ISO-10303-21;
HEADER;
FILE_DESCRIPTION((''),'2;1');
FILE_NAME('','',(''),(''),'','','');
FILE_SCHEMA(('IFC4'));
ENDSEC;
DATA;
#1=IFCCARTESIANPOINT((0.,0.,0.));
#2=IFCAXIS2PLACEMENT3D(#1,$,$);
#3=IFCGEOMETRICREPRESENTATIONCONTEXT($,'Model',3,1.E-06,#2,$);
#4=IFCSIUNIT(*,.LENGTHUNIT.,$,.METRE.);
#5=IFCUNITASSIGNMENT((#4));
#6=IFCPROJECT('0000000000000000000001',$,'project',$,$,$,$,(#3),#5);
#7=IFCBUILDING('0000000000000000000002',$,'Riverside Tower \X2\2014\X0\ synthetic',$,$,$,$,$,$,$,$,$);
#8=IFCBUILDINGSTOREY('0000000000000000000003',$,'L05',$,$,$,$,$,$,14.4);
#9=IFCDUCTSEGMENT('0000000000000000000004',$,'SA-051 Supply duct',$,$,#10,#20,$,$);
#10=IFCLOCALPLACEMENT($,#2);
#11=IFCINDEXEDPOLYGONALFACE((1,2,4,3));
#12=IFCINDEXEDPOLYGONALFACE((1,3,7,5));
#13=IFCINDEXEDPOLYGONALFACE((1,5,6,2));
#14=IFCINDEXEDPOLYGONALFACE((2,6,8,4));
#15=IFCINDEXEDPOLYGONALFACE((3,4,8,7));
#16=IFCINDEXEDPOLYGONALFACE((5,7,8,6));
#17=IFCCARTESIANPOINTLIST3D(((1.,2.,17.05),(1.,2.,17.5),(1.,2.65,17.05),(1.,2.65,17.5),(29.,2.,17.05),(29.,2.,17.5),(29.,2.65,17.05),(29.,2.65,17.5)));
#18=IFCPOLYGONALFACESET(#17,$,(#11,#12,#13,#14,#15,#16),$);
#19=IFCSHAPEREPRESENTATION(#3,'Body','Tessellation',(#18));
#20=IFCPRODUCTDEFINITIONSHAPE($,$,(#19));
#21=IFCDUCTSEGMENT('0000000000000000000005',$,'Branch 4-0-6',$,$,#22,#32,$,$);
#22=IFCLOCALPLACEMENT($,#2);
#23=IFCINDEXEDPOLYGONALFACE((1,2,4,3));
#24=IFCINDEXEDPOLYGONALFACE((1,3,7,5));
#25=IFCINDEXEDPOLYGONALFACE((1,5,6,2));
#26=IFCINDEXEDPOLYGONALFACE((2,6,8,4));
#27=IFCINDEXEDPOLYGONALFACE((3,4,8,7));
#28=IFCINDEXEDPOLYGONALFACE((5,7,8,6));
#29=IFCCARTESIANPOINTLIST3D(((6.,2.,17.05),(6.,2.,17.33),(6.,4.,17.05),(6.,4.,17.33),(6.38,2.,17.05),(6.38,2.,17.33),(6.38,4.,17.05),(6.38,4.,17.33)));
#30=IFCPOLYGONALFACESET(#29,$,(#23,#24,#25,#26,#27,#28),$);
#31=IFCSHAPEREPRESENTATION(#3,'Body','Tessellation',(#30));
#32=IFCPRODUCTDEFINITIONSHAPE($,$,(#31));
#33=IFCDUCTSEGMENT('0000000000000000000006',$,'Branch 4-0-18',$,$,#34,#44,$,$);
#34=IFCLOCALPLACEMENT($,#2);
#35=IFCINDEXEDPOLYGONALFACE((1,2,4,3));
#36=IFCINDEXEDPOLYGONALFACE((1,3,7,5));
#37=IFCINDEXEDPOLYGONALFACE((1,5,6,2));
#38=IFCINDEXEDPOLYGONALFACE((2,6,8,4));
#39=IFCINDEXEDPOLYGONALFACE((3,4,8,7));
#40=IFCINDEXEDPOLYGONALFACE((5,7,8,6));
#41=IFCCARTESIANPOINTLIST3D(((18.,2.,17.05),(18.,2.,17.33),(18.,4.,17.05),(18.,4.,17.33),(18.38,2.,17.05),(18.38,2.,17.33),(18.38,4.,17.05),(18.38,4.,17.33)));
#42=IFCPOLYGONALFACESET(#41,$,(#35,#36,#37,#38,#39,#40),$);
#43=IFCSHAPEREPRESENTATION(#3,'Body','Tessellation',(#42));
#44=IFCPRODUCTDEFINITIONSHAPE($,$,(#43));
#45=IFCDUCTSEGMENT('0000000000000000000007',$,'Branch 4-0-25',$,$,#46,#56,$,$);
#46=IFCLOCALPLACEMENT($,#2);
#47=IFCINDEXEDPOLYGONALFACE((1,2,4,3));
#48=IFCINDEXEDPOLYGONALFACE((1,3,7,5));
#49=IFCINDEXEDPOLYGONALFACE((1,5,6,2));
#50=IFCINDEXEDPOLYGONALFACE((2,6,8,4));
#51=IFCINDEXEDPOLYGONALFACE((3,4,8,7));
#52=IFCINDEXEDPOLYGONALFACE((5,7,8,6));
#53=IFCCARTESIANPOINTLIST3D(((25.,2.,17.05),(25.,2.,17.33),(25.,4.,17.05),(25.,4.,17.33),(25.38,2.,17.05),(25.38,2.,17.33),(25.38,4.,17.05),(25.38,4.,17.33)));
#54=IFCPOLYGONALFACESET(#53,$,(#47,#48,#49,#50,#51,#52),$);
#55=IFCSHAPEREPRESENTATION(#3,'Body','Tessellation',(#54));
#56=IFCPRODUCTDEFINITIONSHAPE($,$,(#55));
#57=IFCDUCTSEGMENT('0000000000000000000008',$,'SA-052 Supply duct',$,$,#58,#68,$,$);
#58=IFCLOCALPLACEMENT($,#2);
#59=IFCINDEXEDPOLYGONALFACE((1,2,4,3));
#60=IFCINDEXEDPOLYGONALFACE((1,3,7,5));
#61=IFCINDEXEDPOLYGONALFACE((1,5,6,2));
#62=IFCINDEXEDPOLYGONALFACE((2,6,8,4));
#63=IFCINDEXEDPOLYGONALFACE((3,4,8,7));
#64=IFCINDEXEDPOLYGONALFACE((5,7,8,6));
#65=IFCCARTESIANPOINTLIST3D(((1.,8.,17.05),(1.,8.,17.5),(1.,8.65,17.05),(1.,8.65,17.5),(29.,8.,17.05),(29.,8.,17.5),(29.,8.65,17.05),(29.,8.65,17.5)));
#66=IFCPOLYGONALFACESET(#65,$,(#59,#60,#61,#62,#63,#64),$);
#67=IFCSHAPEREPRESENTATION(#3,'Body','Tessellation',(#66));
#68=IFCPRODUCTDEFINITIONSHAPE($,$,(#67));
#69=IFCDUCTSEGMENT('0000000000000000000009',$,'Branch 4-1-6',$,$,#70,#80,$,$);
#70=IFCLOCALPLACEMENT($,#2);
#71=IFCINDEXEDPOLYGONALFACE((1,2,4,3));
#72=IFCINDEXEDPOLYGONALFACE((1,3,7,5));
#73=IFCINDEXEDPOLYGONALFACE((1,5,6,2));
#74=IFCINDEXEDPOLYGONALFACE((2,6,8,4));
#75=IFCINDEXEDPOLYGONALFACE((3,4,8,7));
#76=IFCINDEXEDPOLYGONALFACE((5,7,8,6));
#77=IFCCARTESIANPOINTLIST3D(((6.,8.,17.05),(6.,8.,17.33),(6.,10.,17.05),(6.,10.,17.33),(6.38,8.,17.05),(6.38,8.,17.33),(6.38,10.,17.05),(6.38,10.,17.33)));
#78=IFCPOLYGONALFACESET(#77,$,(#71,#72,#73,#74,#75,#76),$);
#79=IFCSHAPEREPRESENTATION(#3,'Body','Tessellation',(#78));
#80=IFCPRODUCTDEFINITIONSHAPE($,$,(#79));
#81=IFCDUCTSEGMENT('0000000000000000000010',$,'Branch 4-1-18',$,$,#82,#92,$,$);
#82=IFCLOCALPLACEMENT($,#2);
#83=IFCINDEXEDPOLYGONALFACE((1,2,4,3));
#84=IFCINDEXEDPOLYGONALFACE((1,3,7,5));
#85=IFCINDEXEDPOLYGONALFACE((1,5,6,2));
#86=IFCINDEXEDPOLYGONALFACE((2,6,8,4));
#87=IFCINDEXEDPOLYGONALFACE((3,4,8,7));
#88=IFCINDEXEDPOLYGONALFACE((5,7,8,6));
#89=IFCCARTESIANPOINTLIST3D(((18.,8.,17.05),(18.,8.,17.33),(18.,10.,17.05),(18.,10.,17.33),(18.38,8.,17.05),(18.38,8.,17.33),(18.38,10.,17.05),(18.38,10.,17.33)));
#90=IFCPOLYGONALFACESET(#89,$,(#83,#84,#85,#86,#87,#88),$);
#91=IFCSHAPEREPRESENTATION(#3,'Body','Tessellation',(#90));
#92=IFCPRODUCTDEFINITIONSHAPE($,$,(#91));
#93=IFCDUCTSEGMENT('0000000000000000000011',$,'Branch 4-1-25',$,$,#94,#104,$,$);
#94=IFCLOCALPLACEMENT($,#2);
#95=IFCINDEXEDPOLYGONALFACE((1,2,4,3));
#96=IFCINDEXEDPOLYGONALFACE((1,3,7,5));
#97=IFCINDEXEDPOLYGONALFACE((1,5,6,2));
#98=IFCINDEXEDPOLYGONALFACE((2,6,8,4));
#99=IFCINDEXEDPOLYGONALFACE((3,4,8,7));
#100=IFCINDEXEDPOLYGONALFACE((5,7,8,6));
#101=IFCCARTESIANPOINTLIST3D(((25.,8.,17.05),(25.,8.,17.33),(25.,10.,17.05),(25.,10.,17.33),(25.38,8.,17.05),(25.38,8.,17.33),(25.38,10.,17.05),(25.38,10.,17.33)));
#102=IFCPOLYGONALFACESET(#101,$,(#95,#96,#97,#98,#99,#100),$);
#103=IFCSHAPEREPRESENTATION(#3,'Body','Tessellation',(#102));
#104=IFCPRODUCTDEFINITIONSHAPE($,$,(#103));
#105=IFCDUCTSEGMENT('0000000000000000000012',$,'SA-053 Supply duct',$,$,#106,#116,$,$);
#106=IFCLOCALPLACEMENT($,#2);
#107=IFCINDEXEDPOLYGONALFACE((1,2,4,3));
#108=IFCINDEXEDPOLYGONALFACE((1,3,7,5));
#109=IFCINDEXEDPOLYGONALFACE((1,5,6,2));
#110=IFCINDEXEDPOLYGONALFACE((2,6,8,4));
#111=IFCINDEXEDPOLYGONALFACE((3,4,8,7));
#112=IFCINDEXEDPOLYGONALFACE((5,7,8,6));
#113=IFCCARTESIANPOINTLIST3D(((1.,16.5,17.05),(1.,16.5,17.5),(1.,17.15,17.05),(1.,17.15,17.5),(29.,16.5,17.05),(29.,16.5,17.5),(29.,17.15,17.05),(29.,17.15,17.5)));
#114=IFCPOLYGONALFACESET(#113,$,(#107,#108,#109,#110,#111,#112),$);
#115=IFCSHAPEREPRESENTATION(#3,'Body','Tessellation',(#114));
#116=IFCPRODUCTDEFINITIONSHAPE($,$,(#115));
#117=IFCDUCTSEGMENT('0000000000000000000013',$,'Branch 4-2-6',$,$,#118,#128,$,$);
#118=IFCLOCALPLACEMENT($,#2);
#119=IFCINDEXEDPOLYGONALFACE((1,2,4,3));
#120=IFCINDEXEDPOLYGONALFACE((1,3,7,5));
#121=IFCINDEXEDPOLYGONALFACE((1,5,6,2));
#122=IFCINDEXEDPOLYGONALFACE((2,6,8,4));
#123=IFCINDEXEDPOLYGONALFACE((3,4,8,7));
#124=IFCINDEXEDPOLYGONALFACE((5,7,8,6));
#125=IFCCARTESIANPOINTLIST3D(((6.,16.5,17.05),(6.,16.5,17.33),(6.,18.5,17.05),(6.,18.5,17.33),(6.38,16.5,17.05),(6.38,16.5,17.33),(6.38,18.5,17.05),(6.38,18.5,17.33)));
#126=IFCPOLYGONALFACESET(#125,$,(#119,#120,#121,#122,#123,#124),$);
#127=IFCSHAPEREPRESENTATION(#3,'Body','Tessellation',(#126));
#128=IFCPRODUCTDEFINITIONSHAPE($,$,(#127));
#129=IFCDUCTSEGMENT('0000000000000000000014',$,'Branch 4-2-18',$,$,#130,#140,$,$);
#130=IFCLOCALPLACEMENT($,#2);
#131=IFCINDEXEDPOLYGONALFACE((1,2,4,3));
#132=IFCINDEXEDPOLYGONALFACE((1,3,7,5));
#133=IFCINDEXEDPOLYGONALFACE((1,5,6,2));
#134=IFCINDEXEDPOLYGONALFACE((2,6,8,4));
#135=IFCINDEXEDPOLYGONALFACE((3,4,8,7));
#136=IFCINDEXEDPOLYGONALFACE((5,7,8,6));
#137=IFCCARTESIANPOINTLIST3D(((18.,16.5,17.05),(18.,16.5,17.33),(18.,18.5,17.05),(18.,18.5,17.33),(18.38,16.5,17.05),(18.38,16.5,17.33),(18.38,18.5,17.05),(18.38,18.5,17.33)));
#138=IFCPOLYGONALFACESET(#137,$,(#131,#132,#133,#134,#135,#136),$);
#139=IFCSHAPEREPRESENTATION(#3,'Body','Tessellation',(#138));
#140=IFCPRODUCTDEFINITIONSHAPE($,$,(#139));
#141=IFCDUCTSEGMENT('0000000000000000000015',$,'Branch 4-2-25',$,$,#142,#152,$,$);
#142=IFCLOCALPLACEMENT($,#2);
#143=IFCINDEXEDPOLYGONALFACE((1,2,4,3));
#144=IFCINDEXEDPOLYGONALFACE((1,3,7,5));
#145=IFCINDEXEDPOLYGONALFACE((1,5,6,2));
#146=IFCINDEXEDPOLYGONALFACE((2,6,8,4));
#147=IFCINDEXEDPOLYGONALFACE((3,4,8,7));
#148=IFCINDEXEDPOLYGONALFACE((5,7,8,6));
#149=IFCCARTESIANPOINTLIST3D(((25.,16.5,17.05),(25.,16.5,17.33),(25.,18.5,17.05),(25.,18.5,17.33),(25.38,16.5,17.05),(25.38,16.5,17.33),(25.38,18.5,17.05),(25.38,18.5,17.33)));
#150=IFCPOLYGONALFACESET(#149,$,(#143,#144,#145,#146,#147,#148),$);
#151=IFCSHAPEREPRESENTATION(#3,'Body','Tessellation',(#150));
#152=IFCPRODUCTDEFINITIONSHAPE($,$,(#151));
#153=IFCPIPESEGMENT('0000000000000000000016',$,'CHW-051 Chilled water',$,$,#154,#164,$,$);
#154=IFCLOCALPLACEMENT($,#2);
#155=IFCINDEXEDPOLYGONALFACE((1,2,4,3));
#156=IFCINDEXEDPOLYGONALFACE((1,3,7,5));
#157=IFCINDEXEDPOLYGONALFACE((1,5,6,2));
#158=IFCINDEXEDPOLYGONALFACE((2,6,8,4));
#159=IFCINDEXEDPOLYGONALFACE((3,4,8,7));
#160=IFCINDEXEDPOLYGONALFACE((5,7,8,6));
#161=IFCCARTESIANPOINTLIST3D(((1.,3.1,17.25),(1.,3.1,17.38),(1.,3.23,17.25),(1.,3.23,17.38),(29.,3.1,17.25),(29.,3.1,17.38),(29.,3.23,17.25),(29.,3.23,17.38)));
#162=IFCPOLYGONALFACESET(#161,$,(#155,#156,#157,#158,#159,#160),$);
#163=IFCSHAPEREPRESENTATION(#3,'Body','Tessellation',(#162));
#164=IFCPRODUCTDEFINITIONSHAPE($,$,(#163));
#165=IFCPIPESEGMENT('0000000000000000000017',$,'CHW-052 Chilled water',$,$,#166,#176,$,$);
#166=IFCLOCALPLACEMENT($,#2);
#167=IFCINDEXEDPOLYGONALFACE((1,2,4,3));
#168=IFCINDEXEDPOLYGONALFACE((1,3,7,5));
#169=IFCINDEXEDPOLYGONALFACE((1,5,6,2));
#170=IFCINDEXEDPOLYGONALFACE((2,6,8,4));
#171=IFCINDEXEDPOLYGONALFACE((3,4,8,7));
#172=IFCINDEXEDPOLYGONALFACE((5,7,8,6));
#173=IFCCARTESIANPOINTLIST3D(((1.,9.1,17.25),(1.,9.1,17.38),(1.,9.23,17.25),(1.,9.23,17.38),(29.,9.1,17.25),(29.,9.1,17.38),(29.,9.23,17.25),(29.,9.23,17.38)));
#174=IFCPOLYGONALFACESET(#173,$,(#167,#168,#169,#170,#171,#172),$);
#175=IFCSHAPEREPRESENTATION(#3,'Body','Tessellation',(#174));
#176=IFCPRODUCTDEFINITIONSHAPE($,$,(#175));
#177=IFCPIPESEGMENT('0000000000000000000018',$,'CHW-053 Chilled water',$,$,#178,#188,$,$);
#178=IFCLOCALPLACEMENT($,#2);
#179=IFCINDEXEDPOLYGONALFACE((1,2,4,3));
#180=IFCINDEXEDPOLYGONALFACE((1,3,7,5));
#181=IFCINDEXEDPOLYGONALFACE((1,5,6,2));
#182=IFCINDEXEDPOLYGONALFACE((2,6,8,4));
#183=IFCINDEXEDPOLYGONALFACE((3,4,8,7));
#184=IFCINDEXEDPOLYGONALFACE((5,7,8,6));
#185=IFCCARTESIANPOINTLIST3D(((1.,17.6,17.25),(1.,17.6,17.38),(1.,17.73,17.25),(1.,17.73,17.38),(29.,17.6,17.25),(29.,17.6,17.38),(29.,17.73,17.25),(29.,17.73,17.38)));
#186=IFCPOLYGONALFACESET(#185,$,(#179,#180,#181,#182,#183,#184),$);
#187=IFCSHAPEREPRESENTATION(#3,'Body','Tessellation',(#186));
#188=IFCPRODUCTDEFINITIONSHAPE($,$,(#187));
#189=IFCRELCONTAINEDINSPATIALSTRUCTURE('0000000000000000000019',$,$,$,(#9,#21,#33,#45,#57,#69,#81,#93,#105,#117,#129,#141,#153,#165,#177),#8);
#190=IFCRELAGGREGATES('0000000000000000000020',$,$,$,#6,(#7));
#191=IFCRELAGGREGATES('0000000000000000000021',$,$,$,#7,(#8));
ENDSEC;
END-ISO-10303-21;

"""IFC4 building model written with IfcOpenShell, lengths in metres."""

from ifc_helpers import new_model, si_unit, frame, origin, place, context, project, spatial, rectangle, extrude, element, save


model = new_model("IFC4")

# Units and contexts
model_context = context("Model", 3, precision=1e-06, world=origin())
ifc_project = project(units=[si_unit("LENGTHUNIT", "METRE")], contexts=[model_context])

# Building, storey
building = spatial("IfcBuilding", under=ifc_project, Name="Riverside Tower — synthetic")
storey = spatial("IfcBuildingStorey", under=building, Name="L05", Elevation=14.4)

# Duct segments
duct_segment_1_placement = place(None, frame((15.0, 2.325, 17.05)))
element("IfcDuctSegment", 1, at=duct_segment_1_placement, inside=storey, Name="SA-051 Supply duct", context=model_context, shape_type="SweptSolid", body=[
    extrude(rectangle(XDim=28.0, YDim=0.65), origin(), (0.0, 0.0, 1.0), 0.45),
])
for number, where, name in (
    (2, (6.19, 3.0, 17.05), "Branch 4-0-6"),
    (3, (18.19, 3.0, 17.05), "Branch 4-0-18"),
    (4, (25.19, 3.0, 17.05), "Branch 4-0-25"),
):
    element("IfcDuctSegment", number, at=place(None, frame(where)), inside=storey, Name=name, context=model_context, shape_type="SweptSolid", body=[
        extrude(rectangle(XDim=0.38, YDim=2.0), origin(), (0.0, 0.0, 1.0), 0.28),
    ])
duct_segment_2_placement = place(None, frame((15.0, 8.325, 17.05)))
element("IfcDuctSegment", 5, at=duct_segment_2_placement, inside=storey, Name="SA-052 Supply duct", context=model_context, shape_type="SweptSolid", body=[
    extrude(rectangle(XDim=28.0, YDim=0.65), origin(), (0.0, 0.0, 1.0), 0.45),
])
for number, where, name in (
    (6, (6.19, 9.0, 17.05), "Branch 4-1-6"),
    (7, (18.19, 9.0, 17.05), "Branch 4-1-18"),
    (8, (25.19, 9.0, 17.05), "Branch 4-1-25"),
):
    element("IfcDuctSegment", number, at=place(None, frame(where)), inside=storey, Name=name, context=model_context, shape_type="SweptSolid", body=[
        extrude(rectangle(XDim=0.38, YDim=2.0), origin(), (0.0, 0.0, 1.0), 0.28),
    ])
duct_segment_3_placement = place(None, frame((15.0, 16.825, 17.05)))
element("IfcDuctSegment", 9, at=duct_segment_3_placement, inside=storey, Name="SA-053 Supply duct", context=model_context, shape_type="SweptSolid", body=[
    extrude(rectangle(XDim=28.0, YDim=0.65), origin(), (0.0, 0.0, 1.0), 0.45),
])
for number, where, name in (
    (10, (6.19, 17.5, 17.05), "Branch 4-2-6"),
    (11, (18.19, 17.5, 17.05), "Branch 4-2-18"),
    (12, (25.19, 17.5, 17.05), "Branch 4-2-25"),
):
    element("IfcDuctSegment", number, at=place(None, frame(where)), inside=storey, Name=name, context=model_context, shape_type="SweptSolid", body=[
        extrude(rectangle(XDim=0.38, YDim=2.0), origin(), (0.0, 0.0, 1.0), 0.28),
    ])

# Pipe segments
for number, where, name in (
    (13, (15.0, 3.165, 17.25), "CHW-051 Chilled water"),
    (14, (15.0, 9.165, 17.25), "CHW-052 Chilled water"),
    (15, (15.0, 17.665, 17.25), "CHW-053 Chilled water"),
):
    element("IfcPipeSegment", number, at=place(None, frame(where)), inside=storey, Name=name, context=model_context, shape_type="SweptSolid", body=[
        extrude(rectangle(XDim=28.0, YDim=0.13), origin(), (0.0, 0.0, 1.0), 0.13),
    ])

save(model, "model.ifc")
